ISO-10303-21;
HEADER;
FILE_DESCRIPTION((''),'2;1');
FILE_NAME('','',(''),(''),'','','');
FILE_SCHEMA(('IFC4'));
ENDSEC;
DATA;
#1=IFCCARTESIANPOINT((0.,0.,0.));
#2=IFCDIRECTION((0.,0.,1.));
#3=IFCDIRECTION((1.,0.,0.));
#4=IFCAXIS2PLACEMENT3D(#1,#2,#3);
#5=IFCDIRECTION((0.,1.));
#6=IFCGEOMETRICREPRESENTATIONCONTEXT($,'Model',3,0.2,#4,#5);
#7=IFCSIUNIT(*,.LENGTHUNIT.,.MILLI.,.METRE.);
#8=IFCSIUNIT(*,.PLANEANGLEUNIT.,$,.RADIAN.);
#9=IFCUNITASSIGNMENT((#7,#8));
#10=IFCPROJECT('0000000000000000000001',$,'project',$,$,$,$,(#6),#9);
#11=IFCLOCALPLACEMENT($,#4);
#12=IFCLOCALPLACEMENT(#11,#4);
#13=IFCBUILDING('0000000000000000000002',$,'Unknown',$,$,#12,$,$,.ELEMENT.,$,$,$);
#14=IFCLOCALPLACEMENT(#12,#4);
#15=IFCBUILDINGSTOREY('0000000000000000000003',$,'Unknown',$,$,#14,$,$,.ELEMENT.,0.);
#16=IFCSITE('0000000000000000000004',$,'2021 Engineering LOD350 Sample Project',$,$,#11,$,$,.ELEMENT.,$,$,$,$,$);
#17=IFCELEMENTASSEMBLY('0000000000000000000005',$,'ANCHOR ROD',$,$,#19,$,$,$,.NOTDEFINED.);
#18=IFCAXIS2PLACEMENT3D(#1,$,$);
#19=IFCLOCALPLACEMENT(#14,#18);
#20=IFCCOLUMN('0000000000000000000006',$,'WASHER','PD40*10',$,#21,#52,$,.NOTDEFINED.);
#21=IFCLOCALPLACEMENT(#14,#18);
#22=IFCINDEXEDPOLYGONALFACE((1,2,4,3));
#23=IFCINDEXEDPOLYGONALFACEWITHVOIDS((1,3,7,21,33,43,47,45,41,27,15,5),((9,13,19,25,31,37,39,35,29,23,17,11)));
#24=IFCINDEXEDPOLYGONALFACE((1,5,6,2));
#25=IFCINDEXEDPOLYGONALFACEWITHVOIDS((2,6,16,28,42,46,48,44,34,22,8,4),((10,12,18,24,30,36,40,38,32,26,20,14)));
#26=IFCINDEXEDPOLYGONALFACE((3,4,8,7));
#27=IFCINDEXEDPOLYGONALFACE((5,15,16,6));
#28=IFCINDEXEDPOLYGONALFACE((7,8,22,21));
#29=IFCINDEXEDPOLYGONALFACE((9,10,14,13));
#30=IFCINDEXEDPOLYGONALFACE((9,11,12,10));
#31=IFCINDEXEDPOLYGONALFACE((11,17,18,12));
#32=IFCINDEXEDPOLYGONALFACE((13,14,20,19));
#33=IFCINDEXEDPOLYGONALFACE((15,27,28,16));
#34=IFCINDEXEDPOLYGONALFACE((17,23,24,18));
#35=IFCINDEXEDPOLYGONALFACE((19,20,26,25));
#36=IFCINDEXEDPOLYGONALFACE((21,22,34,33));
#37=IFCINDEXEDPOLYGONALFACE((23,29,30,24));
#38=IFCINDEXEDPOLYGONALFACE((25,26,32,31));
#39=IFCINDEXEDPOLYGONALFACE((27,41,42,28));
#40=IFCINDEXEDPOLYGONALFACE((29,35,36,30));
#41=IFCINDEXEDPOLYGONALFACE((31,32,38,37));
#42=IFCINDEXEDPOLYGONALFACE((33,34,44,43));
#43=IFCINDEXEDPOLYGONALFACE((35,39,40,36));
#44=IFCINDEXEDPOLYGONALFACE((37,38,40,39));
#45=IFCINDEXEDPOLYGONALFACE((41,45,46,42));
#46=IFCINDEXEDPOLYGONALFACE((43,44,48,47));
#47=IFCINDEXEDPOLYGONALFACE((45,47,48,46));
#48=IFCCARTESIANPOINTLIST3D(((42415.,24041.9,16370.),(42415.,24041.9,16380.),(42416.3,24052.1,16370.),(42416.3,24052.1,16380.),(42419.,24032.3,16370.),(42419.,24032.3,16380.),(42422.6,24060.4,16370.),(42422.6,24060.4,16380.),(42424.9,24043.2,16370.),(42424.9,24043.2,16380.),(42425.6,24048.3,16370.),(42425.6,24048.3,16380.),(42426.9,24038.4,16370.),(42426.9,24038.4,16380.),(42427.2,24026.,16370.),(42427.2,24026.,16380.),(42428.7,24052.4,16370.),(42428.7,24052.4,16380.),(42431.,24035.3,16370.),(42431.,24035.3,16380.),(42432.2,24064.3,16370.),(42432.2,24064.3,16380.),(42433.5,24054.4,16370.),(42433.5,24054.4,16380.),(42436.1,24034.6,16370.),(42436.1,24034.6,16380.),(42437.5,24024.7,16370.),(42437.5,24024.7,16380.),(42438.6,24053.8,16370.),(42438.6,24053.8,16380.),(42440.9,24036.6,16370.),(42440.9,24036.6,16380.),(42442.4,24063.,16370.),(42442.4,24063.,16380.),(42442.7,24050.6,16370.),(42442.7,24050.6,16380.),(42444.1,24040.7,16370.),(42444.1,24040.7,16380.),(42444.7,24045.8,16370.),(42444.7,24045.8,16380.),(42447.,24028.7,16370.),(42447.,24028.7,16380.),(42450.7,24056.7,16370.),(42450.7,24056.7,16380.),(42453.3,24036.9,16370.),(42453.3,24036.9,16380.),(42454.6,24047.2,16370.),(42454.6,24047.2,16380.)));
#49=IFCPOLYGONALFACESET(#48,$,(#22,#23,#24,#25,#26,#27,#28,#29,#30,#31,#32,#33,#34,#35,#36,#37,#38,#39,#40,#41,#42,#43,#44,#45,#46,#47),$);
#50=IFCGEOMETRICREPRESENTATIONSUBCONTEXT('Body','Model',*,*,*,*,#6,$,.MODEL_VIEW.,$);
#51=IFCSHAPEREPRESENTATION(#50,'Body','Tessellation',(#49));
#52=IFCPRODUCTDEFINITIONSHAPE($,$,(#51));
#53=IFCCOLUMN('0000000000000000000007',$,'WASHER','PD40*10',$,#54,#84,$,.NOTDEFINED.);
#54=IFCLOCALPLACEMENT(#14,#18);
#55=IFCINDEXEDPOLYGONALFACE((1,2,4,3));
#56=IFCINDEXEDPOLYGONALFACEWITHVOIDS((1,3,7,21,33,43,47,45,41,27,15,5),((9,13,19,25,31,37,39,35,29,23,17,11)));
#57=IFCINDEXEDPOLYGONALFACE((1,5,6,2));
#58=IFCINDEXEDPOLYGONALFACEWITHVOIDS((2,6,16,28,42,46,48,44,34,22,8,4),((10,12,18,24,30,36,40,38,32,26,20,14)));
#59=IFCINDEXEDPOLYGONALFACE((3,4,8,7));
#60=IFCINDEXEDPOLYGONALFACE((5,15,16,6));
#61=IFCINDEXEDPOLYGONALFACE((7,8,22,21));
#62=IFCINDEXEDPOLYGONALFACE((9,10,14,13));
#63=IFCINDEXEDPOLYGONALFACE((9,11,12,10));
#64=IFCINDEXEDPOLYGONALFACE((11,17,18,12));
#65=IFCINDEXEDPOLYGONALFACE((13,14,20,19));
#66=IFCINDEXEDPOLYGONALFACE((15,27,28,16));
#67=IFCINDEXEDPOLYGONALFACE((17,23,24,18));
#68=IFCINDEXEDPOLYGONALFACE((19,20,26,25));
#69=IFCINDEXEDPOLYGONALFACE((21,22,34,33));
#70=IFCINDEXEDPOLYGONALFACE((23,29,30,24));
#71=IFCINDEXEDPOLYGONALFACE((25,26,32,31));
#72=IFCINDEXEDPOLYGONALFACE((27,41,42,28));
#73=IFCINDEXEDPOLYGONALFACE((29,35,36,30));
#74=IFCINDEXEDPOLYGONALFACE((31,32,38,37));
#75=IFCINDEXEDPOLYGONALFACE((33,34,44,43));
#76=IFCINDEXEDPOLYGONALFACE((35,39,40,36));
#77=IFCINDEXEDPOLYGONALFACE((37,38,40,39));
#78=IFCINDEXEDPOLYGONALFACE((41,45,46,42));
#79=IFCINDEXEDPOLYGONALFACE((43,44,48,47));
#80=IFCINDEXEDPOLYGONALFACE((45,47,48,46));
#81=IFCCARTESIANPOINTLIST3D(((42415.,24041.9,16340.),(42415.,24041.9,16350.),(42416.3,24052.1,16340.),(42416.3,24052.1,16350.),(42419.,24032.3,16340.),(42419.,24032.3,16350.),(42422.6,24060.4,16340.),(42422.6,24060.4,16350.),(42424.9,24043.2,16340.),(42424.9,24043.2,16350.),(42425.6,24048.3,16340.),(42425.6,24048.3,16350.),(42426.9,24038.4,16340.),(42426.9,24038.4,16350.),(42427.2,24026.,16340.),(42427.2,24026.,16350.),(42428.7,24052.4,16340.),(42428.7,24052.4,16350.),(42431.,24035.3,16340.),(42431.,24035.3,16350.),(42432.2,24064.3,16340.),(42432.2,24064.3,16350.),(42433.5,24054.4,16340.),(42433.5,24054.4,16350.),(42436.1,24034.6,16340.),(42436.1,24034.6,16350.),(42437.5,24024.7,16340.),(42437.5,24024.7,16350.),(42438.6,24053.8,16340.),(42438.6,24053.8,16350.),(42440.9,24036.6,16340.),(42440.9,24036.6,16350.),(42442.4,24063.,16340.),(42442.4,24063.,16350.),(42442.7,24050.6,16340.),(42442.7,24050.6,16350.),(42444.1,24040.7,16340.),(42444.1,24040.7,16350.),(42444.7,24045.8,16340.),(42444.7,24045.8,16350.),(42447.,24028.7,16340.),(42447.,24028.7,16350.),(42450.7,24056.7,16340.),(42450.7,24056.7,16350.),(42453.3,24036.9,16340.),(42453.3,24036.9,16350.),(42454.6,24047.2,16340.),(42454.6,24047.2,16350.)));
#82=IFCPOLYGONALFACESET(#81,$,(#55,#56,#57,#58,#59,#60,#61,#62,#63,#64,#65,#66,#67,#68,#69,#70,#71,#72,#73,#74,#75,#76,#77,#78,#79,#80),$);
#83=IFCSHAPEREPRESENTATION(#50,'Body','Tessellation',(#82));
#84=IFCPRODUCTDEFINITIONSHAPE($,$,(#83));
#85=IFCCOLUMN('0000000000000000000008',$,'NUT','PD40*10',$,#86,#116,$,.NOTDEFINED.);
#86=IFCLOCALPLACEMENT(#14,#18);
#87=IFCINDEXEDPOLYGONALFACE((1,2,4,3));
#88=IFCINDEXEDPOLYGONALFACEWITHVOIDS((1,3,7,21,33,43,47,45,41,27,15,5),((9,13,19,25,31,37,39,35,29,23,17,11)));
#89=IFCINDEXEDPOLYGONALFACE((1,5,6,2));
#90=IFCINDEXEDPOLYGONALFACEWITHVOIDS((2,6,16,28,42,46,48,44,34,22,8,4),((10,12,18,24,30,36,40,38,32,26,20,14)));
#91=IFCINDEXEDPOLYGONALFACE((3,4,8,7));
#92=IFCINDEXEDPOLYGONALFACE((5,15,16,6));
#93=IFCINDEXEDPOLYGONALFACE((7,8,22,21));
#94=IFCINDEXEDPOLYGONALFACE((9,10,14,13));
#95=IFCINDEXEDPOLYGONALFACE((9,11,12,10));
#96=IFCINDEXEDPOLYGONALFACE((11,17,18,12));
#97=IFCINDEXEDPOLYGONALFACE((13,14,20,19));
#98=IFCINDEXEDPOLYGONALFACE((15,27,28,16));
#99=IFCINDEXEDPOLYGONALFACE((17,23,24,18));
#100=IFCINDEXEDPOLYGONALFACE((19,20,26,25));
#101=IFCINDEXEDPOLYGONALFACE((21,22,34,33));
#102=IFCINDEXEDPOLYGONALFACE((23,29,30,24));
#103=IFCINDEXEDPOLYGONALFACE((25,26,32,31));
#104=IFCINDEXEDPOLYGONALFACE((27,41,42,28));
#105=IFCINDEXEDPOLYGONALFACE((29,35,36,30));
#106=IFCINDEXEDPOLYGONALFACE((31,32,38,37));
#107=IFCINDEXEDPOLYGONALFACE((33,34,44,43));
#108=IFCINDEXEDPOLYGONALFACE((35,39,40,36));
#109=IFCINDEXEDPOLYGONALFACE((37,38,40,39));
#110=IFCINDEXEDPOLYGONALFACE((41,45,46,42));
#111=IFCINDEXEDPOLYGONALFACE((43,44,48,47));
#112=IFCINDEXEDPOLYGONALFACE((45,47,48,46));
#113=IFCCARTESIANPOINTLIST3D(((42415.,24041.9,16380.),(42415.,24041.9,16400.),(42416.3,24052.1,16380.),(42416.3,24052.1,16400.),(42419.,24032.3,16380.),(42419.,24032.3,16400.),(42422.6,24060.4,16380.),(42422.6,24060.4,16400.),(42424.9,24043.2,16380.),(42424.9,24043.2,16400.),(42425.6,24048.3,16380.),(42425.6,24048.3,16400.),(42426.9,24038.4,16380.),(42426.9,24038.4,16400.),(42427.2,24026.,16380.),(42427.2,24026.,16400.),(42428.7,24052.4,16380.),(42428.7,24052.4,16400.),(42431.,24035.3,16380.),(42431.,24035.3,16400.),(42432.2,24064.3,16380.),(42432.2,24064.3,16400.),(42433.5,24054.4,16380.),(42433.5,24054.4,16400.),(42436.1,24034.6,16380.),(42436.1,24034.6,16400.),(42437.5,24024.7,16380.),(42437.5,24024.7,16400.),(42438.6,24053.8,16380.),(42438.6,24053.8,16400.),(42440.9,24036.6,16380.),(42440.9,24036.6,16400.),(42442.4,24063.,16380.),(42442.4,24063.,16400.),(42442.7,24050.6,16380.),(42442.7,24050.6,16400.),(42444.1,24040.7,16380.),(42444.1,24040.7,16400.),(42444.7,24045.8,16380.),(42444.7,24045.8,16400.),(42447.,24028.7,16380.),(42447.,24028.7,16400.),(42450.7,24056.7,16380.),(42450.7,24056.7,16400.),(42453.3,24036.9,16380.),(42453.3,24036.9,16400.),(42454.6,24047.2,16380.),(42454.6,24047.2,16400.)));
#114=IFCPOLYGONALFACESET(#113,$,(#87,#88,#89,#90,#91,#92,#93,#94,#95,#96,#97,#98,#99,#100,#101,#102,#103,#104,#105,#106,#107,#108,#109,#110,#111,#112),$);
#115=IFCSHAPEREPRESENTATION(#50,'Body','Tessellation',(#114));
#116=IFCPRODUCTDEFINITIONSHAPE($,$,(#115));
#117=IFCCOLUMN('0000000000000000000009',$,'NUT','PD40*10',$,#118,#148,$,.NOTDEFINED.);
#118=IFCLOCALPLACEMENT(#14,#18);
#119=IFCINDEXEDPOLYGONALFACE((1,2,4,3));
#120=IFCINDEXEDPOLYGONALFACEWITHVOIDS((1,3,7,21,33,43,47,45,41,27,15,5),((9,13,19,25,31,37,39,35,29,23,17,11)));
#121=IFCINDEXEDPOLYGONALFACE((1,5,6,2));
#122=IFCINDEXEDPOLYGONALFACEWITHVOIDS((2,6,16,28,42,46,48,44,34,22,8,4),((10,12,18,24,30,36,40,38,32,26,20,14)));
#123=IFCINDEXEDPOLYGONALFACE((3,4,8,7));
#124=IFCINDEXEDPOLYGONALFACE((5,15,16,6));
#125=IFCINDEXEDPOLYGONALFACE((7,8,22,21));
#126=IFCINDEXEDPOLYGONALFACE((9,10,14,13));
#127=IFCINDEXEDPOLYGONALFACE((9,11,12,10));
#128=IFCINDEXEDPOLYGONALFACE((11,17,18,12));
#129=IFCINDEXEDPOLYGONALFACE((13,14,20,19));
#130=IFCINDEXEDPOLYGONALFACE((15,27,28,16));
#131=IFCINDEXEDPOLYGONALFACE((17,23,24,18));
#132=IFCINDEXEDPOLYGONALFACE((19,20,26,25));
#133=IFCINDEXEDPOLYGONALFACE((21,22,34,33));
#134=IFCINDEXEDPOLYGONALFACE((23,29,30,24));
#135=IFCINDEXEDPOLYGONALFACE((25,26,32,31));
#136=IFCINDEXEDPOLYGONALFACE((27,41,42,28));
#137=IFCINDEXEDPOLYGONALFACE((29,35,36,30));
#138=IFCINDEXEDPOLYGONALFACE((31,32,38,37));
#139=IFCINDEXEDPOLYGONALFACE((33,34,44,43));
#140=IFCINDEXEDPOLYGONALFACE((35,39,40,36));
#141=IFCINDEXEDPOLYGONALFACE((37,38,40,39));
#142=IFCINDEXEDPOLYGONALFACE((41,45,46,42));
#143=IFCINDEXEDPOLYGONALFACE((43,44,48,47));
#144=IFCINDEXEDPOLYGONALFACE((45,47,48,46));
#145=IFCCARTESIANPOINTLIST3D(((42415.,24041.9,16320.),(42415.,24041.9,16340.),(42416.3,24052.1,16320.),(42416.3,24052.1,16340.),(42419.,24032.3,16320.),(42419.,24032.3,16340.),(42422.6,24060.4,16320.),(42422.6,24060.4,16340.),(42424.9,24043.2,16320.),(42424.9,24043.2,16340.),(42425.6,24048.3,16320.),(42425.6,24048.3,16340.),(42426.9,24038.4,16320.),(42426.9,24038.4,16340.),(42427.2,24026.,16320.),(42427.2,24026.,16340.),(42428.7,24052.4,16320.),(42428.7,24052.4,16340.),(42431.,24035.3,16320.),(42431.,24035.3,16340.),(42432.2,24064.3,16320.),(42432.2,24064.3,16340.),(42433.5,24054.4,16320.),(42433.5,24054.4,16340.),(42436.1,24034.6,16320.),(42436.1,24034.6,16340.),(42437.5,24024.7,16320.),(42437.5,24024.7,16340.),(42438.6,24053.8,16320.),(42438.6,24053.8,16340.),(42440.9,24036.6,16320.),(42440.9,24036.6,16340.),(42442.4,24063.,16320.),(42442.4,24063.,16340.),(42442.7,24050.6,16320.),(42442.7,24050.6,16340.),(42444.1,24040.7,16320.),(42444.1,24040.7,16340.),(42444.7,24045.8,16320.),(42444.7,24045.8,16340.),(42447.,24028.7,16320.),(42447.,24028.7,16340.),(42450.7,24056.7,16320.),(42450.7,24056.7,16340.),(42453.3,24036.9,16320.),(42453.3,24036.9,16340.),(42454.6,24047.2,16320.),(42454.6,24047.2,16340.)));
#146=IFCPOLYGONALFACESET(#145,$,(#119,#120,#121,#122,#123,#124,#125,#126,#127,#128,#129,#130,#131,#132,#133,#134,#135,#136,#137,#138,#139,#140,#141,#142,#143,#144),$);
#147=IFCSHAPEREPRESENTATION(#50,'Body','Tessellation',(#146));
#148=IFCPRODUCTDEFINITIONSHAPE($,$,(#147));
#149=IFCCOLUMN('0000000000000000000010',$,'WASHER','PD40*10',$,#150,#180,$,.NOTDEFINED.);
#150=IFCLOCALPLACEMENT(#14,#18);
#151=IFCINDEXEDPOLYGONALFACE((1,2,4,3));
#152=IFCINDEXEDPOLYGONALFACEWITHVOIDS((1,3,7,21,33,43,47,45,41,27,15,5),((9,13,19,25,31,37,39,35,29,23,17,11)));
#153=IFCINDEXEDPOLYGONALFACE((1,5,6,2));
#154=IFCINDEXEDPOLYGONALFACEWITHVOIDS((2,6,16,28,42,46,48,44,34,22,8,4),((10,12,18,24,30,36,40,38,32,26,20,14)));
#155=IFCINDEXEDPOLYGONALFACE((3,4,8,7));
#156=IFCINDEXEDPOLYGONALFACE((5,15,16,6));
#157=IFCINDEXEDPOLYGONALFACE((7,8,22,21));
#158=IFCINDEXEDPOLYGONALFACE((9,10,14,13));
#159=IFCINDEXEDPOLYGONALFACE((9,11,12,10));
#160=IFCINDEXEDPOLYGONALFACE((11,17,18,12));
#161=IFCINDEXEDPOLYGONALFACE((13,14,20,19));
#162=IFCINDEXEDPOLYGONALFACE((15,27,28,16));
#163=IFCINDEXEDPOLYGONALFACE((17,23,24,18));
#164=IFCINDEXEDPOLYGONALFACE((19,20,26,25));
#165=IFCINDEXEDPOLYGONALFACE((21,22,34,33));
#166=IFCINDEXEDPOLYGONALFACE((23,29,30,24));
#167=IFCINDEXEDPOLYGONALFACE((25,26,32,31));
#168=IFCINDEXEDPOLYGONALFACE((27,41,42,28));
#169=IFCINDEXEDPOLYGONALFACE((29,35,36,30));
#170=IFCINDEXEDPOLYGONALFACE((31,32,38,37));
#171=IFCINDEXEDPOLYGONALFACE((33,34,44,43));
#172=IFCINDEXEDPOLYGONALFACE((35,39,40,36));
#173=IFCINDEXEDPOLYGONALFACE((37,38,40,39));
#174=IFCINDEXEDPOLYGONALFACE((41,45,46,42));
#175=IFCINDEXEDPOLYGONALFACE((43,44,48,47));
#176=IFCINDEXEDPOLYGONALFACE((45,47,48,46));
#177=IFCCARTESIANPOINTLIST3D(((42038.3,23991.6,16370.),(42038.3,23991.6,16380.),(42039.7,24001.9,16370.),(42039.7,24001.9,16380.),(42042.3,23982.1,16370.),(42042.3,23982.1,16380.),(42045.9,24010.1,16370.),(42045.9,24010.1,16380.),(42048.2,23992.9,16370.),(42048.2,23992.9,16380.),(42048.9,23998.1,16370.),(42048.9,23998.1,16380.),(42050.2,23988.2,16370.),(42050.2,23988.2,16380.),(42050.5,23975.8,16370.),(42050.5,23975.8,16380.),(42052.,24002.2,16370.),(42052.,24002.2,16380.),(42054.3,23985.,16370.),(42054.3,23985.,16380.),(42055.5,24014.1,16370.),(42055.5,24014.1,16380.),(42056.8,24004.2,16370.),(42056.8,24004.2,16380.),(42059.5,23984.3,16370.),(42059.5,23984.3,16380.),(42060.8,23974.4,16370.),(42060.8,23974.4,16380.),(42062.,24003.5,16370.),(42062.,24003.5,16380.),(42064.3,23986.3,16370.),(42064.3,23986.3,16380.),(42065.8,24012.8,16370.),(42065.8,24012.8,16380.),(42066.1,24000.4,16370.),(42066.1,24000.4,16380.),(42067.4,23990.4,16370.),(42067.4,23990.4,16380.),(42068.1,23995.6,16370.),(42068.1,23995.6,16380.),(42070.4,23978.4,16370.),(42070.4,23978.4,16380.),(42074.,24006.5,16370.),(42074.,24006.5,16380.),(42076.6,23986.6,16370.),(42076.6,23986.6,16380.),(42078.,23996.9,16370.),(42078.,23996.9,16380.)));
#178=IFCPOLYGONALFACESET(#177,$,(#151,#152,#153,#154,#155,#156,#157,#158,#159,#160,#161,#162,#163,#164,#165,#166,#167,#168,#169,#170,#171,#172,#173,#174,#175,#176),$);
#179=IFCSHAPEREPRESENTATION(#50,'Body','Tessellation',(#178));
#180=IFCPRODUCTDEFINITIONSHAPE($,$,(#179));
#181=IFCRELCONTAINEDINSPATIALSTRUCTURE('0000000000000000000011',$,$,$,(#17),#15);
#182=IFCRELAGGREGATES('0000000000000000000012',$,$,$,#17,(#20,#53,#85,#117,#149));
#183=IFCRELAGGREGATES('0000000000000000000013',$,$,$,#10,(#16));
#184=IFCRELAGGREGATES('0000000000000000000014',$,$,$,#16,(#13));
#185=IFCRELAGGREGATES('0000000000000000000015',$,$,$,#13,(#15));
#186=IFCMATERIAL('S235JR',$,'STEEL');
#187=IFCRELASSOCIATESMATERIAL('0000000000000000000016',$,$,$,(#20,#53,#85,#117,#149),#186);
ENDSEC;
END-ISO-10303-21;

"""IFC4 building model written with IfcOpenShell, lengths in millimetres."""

from ifc_helpers import new_model, si_unit, direction, frame, origin_with_axes, place, context, subcontext, project, spatial, line, indexed_curve, outline, extrude, material, element, aggregate, save


model = new_model("IFC4")

# Units and contexts
model_context = context("Model", 3, precision=0.2, world=origin_with_axes(), true_north=direction((0.0, 1.0)))
body_context = subcontext(model_context, "Body", "Model", "MODEL_VIEW")
ifc_project = project(units=[si_unit("LENGTHUNIT", "METRE", prefix="MILLI"), si_unit("PLANEANGLEUNIT", "RADIAN")], contexts=[model_context])

# Site, building, storey
site_placement = place(None, origin_with_axes())
site = spatial("IfcSite", under=ifc_project, at=site_placement, Name="2021 Engineering LOD350 Sample Project", CompositionType="ELEMENT")
building_placement = place(site_placement, origin_with_axes())
building = spatial("IfcBuilding", under=site, at=building_placement, Name="Unknown", CompositionType="ELEMENT")
storey_placement = place(building_placement, origin_with_axes())
storey = spatial("IfcBuildingStorey", under=building, at=storey_placement, Name="Unknown", CompositionType="ELEMENT", Elevation=0.0)

# Element assembly, columns
assembly_1_placement = place(storey_placement, frame((42408.4, 24242.8, 16410.0), z_axis=(0.991216, 0.132256, 0.0), x_axis=(0.0, 0.0, -1.0)))
assembly_1 = element("IfcElementAssembly", 1, at=assembly_1_placement, inside=storey, Name="ANCHOR ROD", PredefinedType="NOTDEFINED")
ifc_material_1 = material(Name="S235JR", Category="STEEL")
column_1_placement = place(assembly_1_placement, frame((30.0, -200.0, 0.0), z_axis=(0.0, 0.0, 1.0), x_axis=(1.0, 0.0, 0.0)))
column_1 = element("IfcColumn", 2, at=column_1_placement, material=ifc_material_1, Name="WASHER", Description="PD40*10", PredefinedType="NOTDEFINED", context=body_context, shape_type="SolidModel", body=[
    extrude(outline(indexed_curve([(20.0, 0.0), (17.3, 10.0), (10.0, 17.3), (0.0, 20.0), (-10.0, 17.3), (-17.3, 10.0), (-20.0, 0.0), (-17.3, -10.0), (-10.0, -17.3), (0.0, -20.0), (10.0, -17.3), (17.3, -10.0)], segments=[line(1, 2, 3, 4, 5, 6, 7, 8, 9, 10, 11, 12, 1)]), holes=[indexed_curve([(10.0, 0.0), (8.7, -5.0), (5.0, -8.7), (0.0, -10.0), (-5.0, -8.7), (-8.7, -5.0), (-10.0, 0.0), (-8.7, 5.0), (-5.0, 8.7), (0.0, 10.0), (5.0, 8.7), (8.7, 5.0)], segments=[line(1, 2, 3, 4, 5, 6, 7, 8, 9, 10, 11, 12, 1)])]), frame((0.0, 0.0, 0.0), z_axis=(-1.0, 0.0, 0.0), x_axis=(0.0, 0.0, 1.0)), (0.0, 0.0, -1.0), 10.0),
])
column_2_placement = place(assembly_1_placement, frame((60.0, -200.0, 0.0), z_axis=(0.0, 0.0, 1.0), x_axis=(1.0, 0.0, 0.0)))
column_2 = element("IfcColumn", 3, at=column_2_placement, material=ifc_material_1, Name="WASHER", Description="PD40*10", PredefinedType="NOTDEFINED", context=body_context, shape_type="SolidModel", body=[
    extrude(outline(indexed_curve([(20.0, 0.0), (17.3, 10.0), (10.0, 17.3), (0.0, 20.0), (-10.0, 17.3), (-17.3, 10.0), (-20.0, 0.0), (-17.3, -10.0), (-10.0, -17.3), (0.0, -20.0), (10.0, -17.3), (17.3, -10.0)], segments=[line(1, 2, 3, 4, 5, 6, 7, 8, 9, 10, 11, 12, 1)]), holes=[indexed_curve([(10.0, 0.0), (8.7, -5.0), (5.0, -8.7), (0.0, -10.0), (-5.0, -8.7), (-8.7, -5.0), (-10.0, 0.0), (-8.7, 5.0), (-5.0, 8.7), (0.0, 10.0), (5.0, 8.7), (8.7, 5.0)], segments=[line(1, 2, 3, 4, 5, 6, 7, 8, 9, 10, 11, 12, 1)])]), frame((0.0, 0.0, 0.0), z_axis=(-1.0, 0.0, 0.0), x_axis=(0.0, 0.0, 1.0)), (0.0, 0.0, -1.0), 10.0),
])
column_3_placement = place(assembly_1_placement, frame((10.0, -200.0, 0.0), z_axis=(0.0, 0.0, 1.0), x_axis=(1.0, 0.0, 0.0)))
column_3 = element("IfcColumn", 4, at=column_3_placement, material=ifc_material_1, Name="NUT", Description="PD40*10", PredefinedType="NOTDEFINED", context=body_context, shape_type="SolidModel", body=[
    extrude(outline(indexed_curve([(20.0, 0.0), (17.3, 10.0), (10.0, 17.3), (0.0, 20.0), (-10.0, 17.3), (-17.3, 10.0), (-20.0, 0.0), (-17.3, -10.0), (-10.0, -17.3), (0.0, -20.0), (10.0, -17.3), (17.3, -10.0)], segments=[line(1, 2, 3, 4, 5, 6, 7, 8, 9, 10, 11, 12, 1)]), holes=[indexed_curve([(10.0, 0.0), (8.7, -5.0), (5.0, -8.7), (0.0, -10.0), (-5.0, -8.7), (-8.7, -5.0), (-10.0, 0.0), (-8.7, 5.0), (-5.0, 8.7), (0.0, 10.0), (5.0, 8.7), (8.7, 5.0)], segments=[line(1, 2, 3, 4, 5, 6, 7, 8, 9, 10, 11, 12, 1)])]), frame((0.0, 0.0, 0.0), z_axis=(-1.0, 0.0, 0.0), x_axis=(0.0, 0.0, 1.0)), (0.0, 0.0, -1.0), 20.0),
])
column_4_placement = place(assembly_1_placement, frame((70.0, -200.0, 0.0), z_axis=(0.0, 0.0, 1.0), x_axis=(1.0, 0.0, 0.0)))
column_4 = element("IfcColumn", 5, at=column_4_placement, material=ifc_material_1, Name="NUT", Description="PD40*10", PredefinedType="NOTDEFINED", context=body_context, shape_type="SolidModel", body=[
    extrude(outline(indexed_curve([(20.0, 0.0), (17.3, 10.0), (10.0, 17.3), (0.0, 20.0), (-10.0, 17.3), (-17.3, 10.0), (-20.0, 0.0), (-17.3, -10.0), (-10.0, -17.3), (0.0, -20.0), (10.0, -17.3), (17.3, -10.0)], segments=[line(1, 2, 3, 4, 5, 6, 7, 8, 9, 10, 11, 12, 1)]), holes=[indexed_curve([(10.0, 0.0), (8.7, -5.0), (5.0, -8.7), (0.0, -10.0), (-5.0, -8.7), (-8.7, -5.0), (-10.0, 0.0), (-8.7, 5.0), (-5.0, 8.7), (0.0, 10.0), (5.0, 8.7), (8.7, 5.0)], segments=[line(1, 2, 3, 4, 5, 6, 7, 8, 9, 10, 11, 12, 1)])]), frame((0.0, 0.0, 0.0), z_axis=(-1.0, 0.0, 0.0), x_axis=(0.0, 0.0, 1.0)), (0.0, 0.0, -1.0), 20.0),
])
column_5_placement = place(assembly_1_placement, frame((30.0, -200.0, -380.0), z_axis=(0.0, 0.0, -1.0), x_axis=(1.0, 0.0, 0.0)))
column_5 = element("IfcColumn", 6, at=column_5_placement, material=ifc_material_1, Name="WASHER", Description="PD40*10", PredefinedType="NOTDEFINED", context=body_context, shape_type="SolidModel", body=[
    extrude(outline(indexed_curve([(20.0, 0.0), (17.3, 10.0), (10.0, 17.3), (0.0, 20.0), (-10.0, 17.3), (-17.3, 10.0), (-20.0, 0.0), (-17.3, -10.0), (-10.0, -17.3), (0.0, -20.0), (10.0, -17.3), (17.3, -10.0)], segments=[line(1, 2, 3, 4, 5, 6, 7, 8, 9, 10, 11, 12, 1)]), holes=[indexed_curve([(10.0, 0.0), (8.7, -5.0), (5.0, -8.7), (0.0, -10.0), (-5.0, -8.7), (-8.7, -5.0), (-10.0, 0.0), (-8.7, 5.0), (-5.0, 8.7), (0.0, 10.0), (5.0, 8.7), (8.7, 5.0)], segments=[line(1, 2, 3, 4, 5, 6, 7, 8, 9, 10, 11, 12, 1)])]), frame((0.0, 0.0, 0.0), z_axis=(-1.0, 0.0, 0.0), x_axis=(0.0, 0.0, 1.0)), (0.0, 0.0, -1.0), 10.0),
])

aggregate(assembly_1, [column_1, column_2, column_3, column_4, column_5])

save(model, "model.ifc")
